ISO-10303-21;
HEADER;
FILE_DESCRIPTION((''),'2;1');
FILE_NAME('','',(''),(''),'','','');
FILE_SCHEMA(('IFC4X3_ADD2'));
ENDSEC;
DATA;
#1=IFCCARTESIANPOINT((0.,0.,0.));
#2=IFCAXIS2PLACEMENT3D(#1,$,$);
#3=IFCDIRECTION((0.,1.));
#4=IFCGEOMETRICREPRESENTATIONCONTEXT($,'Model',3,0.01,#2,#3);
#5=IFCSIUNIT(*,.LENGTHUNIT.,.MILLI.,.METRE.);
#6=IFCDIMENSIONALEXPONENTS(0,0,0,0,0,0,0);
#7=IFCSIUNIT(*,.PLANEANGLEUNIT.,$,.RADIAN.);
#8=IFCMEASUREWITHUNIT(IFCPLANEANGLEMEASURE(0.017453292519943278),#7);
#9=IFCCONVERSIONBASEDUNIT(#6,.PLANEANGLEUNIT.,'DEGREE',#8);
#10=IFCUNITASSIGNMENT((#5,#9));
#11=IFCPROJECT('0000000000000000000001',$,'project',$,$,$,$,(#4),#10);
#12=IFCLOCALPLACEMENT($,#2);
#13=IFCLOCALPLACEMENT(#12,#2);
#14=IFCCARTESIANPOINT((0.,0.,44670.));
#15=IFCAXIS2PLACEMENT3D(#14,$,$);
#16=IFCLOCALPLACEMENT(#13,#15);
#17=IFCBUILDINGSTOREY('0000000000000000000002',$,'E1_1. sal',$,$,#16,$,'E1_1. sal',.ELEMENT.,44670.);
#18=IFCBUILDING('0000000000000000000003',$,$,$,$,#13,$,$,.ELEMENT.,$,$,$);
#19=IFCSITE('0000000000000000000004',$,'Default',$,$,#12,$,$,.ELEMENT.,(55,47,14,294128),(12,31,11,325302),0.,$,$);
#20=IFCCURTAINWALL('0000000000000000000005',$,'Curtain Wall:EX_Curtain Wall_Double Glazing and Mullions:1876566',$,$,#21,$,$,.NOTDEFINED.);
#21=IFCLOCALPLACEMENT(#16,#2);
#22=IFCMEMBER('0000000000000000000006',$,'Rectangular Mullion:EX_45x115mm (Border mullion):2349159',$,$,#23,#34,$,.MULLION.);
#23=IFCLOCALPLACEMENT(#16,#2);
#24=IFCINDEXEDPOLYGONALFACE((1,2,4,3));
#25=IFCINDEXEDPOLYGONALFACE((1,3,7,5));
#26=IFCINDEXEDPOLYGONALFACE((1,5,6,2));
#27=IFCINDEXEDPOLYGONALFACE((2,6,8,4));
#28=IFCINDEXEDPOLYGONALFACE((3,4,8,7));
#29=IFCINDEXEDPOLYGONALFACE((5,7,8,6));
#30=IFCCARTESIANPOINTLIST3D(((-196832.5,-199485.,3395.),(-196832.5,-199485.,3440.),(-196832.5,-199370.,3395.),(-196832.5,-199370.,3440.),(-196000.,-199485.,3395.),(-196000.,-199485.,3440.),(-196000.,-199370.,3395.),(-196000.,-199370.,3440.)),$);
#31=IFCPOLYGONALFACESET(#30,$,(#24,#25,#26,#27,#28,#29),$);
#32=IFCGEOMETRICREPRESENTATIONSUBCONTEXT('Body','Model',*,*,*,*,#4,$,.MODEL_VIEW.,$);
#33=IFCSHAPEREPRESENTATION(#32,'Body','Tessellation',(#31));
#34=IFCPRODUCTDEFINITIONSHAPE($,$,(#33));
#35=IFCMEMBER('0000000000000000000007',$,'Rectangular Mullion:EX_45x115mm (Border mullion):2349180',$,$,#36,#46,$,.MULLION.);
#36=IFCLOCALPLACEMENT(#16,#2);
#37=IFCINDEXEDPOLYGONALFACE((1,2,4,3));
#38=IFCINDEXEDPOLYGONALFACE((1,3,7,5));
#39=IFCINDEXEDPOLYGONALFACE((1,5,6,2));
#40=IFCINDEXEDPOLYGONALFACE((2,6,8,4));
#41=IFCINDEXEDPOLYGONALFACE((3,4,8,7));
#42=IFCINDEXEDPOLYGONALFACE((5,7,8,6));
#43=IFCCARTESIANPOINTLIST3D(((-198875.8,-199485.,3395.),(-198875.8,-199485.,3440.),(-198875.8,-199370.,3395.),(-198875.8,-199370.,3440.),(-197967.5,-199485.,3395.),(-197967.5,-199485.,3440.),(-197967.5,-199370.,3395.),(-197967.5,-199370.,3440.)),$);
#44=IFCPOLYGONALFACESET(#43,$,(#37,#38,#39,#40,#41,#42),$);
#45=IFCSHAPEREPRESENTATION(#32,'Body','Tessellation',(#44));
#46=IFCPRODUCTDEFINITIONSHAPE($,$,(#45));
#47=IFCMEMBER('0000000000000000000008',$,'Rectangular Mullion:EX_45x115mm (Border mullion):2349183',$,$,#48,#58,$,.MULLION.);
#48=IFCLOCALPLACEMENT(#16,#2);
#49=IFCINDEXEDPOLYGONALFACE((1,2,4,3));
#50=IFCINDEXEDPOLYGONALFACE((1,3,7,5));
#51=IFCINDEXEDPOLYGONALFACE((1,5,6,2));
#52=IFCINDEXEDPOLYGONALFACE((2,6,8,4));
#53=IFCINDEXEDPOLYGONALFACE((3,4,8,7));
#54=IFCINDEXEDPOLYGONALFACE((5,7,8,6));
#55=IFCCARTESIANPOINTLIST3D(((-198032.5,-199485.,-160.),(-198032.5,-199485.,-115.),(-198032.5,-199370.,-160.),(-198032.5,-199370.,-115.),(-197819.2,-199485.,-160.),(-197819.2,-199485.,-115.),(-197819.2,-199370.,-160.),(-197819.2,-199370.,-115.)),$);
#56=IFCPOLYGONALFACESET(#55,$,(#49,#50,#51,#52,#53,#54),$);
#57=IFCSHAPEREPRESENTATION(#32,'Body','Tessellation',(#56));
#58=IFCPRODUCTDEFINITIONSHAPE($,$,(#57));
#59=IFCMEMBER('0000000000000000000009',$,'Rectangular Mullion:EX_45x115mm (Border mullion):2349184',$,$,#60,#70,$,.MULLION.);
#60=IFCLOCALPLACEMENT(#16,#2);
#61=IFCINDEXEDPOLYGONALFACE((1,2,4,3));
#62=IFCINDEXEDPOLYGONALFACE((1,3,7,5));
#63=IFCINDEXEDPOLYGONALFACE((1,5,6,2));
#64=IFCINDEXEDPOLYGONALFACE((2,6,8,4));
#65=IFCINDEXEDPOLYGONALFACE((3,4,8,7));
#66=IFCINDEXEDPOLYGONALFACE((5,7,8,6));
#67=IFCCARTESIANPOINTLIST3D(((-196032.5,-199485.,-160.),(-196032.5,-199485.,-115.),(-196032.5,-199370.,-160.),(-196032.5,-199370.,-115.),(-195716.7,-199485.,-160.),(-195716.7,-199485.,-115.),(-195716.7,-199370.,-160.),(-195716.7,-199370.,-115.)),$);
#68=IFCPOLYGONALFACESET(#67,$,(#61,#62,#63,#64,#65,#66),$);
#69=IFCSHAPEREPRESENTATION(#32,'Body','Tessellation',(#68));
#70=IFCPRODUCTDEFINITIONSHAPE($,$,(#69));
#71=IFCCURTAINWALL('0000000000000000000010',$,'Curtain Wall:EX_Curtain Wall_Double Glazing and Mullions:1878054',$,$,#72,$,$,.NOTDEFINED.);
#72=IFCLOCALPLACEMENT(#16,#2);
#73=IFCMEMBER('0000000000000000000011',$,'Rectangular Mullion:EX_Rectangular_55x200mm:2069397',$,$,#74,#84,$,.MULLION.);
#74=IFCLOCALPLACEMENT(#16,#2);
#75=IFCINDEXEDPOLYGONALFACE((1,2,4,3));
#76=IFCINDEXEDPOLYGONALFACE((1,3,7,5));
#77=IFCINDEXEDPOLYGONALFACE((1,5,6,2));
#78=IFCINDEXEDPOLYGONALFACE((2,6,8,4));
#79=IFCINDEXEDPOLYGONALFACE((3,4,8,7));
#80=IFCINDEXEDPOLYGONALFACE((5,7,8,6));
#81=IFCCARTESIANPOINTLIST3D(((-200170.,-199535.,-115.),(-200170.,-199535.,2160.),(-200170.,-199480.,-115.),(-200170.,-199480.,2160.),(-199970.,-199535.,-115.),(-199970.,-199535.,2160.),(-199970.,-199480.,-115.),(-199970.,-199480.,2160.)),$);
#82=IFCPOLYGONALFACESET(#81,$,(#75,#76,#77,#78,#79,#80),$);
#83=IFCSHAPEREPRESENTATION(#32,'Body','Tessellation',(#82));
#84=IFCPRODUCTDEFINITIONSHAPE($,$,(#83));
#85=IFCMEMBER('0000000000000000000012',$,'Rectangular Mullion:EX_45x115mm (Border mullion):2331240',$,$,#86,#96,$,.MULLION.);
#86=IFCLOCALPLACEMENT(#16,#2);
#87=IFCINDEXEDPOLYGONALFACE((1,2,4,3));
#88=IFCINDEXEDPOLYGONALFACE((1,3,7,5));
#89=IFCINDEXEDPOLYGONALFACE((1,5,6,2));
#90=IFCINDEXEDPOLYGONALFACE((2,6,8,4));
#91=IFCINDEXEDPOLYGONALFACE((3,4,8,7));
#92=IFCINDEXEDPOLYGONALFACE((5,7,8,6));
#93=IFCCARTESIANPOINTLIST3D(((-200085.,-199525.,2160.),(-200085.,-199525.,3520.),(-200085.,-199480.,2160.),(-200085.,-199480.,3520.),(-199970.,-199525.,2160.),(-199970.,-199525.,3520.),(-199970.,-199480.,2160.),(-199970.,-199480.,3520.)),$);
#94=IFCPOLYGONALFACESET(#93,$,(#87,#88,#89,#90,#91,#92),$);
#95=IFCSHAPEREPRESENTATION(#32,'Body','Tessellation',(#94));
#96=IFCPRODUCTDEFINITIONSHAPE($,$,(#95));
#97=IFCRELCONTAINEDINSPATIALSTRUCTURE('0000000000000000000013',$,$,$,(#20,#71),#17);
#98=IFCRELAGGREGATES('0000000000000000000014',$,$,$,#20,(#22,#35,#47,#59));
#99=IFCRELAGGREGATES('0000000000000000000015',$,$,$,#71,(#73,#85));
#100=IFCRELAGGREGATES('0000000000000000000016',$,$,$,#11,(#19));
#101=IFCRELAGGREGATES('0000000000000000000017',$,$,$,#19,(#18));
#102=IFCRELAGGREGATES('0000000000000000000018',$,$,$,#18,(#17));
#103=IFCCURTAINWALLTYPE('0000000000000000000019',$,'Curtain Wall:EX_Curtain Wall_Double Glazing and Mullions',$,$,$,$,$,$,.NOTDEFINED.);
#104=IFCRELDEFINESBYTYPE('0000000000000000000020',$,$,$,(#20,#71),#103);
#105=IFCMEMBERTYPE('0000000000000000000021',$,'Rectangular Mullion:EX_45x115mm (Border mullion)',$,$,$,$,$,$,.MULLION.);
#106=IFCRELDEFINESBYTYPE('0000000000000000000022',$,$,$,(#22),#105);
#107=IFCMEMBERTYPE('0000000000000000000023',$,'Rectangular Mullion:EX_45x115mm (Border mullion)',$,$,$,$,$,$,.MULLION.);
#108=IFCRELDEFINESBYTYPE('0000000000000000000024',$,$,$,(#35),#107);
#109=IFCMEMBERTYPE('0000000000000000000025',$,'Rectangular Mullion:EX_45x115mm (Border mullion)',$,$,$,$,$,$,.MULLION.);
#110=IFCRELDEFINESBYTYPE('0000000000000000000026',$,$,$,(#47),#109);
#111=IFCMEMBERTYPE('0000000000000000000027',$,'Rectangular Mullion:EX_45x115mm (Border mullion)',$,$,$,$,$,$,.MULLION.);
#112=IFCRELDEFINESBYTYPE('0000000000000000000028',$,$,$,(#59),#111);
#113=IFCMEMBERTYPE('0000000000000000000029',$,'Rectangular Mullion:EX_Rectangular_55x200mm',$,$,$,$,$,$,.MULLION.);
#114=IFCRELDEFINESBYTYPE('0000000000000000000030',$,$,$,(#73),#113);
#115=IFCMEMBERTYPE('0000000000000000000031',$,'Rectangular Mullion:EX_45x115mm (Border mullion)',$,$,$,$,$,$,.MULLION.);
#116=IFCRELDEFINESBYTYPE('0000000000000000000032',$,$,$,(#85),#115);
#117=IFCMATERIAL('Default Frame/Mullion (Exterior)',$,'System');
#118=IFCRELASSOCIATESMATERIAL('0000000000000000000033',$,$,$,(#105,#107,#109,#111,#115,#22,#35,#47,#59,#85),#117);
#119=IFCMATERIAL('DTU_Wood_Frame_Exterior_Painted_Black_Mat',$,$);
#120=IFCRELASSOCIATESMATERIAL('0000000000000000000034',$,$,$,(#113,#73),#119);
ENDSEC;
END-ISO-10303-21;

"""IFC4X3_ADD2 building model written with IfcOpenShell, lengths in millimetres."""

from ifc_helpers import new_model, entity, si_unit, converted_unit, direction, frame, origin, origin_2d_with_axis, place, context, subcontext, project, spatial, rectangle, extrude, source, transform, mapped, material, material_profile, profile_set, profile_usage, type_object, type_shapes, element, aggregate, save


model = new_model("IFC4X3_ADD2")

# Units and contexts
model_context = context("Model", 3, precision=0.01, world=origin(), true_north=direction((0.0, 1.0)))
body_context = subcontext(model_context, "Body", "Model", "MODEL_VIEW")
ifc_project = project(units=[si_unit("LENGTHUNIT", "METRE", prefix="MILLI"), converted_unit("PLANEANGLEUNIT", "DEGREE", entity("IfcPlaneAngleMeasure", 0.017453292519943278), si_unit("PLANEANGLEUNIT", "RADIAN"), dimensions=[0, 0, 0, 0, 0, 0, 0])], contexts=[model_context])

# Site, building, storey
site_placement = place(None, origin())
site = spatial("IfcSite", under=ifc_project, at=site_placement, Name="Default", CompositionType="ELEMENT", RefLatitude=(55, 47, 14, 294128), RefLongitude=(12, 31, 11, 325302), RefElevation=0.0)
building_placement = place(site_placement, origin())
building = spatial("IfcBuilding", under=site, at=building_placement, CompositionType="ELEMENT")
storey_placement = place(building_placement, frame((0.0, 0.0, 44670.0)))
storey = spatial("IfcBuildingStorey", under=building, at=storey_placement, Name="E1_1. sal", LongName="E1_1. sal", CompositionType="ELEMENT", Elevation=44670.0)

# Curtain walls, members
curtain_wall_type = type_object("IfcCurtainWallType", Name="Curtain Wall:EX_Curtain Wall_Double Glazing and Mullions", PredefinedType="NOTDEFINED")
curtain_wall_1_placement = place(storey_placement, frame((0.0, 0.0, -44670.0)))
curtain_wall_1 = element("IfcCurtainWall", 1, at=curtain_wall_1_placement, inside=storey, type_object=curtain_wall_type, Name="Curtain Wall:EX_Curtain Wall_Double Glazing and Mullions:1876566", PredefinedType="NOTDEFINED")
ifc_material_1 = material(Name="DTU_Wood_Frame_Exterior_Painted_Black_Mat")
ifc_material_profile_1 = material_profile(ifc_material_1, rectangle(XDim=55.0, YDim=200.0, at=origin_2d_with_axis()), Name="EX_Rectangular_55x200mm")
ifc_profile_set_1 = profile_set([ifc_material_profile_1], Name="EX_Rectangular_55x200mm")
ifc_profile_usage_1 = profile_usage(ifc_profile_set_1)
ifc_material_2 = material(Name="Default Frame/Mullion (Exterior)", Category="System")
ifc_material_profile_2 = material_profile(ifc_material_2, rectangle(XDim=45.0, YDim=115.0, at=origin_2d_with_axis()), Name="EX_45x115mm (Border mullion)")
ifc_profile_set_2 = profile_set([ifc_material_profile_2], Name="EX_45x115mm (Border mullion)")
ifc_profile_usage_2 = profile_usage(ifc_profile_set_2)
member_type_1 = type_object("IfcMemberType", Name="Rectangular Mullion:EX_45x115mm (Border mullion)", PredefinedType="MULLION", material=ifc_profile_set_2)
shared_shape_1 = source(origin(), body_context, "Body", "SweptSolid", [
    extrude(rectangle(XDim=45.0, YDim=115.0, at=origin_2d_with_axis()), frame((-22.5, -57.5, -832.5), z_axis=(0.0, 0.0, 1.0), x_axis=(-1.0, 0.0, 0.0)), (0.0, 0.0, 1.0), 832.5),
])
type_shapes(member_type_1, [shared_shape_1])
member_1_placement = place(curtain_wall_1_placement, frame((-196000.0, -199485.0, 48110.0), z_axis=(1.0, 0.0, 0.0), x_axis=(0.0, 0.0, 1.0)))
member_1 = element("IfcMember", 2, at=member_1_placement, type_object=member_type_1, material=ifc_profile_usage_2, Name="Rectangular Mullion:EX_45x115mm (Border mullion):2349159", PredefinedType="MULLION", context=body_context, shape_type="MappedRepresentation", body=[
    mapped(shared_shape_1, transform((0.0, 0.0, 0.0), scale=1.0)),
])
member_type_2 = type_object("IfcMemberType", Name="Rectangular Mullion:EX_45x115mm (Border mullion)", PredefinedType="MULLION", material=ifc_profile_set_2)
shared_shape_2 = source(origin(), body_context, "Body", "SweptSolid", [
    extrude(rectangle(XDim=45.0, YDim=115.0, at=origin_2d_with_axis()), frame((-22.5, -57.5, -908.3), z_axis=(0.0, 0.0, 1.0), x_axis=(-1.0, 0.0, 0.0)), (0.0, 0.0, 1.0), 908.3),
])
type_shapes(member_type_2, [shared_shape_2])
member_2_placement = place(curtain_wall_1_placement, frame((-197967.5, -199485.0, 48110.0), z_axis=(1.0, 0.0, 0.0), x_axis=(0.0, 0.0, 1.0)))
member_2 = element("IfcMember", 3, at=member_2_placement, type_object=member_type_2, material=ifc_profile_usage_2, Name="Rectangular Mullion:EX_45x115mm (Border mullion):2349180", PredefinedType="MULLION", context=body_context, shape_type="MappedRepresentation", body=[
    mapped(shared_shape_2, transform((0.0, 0.0, 0.0), scale=1.0)),
])
member_type_3 = type_object("IfcMemberType", Name="Rectangular Mullion:EX_45x115mm (Border mullion)", PredefinedType="MULLION", material=ifc_profile_set_2)
shared_shape_3 = source(origin(), body_context, "Body", "SweptSolid", [
    extrude(rectangle(XDim=45.0, YDim=115.0, at=origin_2d_with_axis()), frame((-22.5, -57.5, -213.3), z_axis=(0.0, 0.0, 1.0), x_axis=(-1.0, 0.0, 0.0)), (0.0, 0.0, 1.0), 213.3),
])
type_shapes(member_type_3, [shared_shape_3])
member_3_placement = place(curtain_wall_1_placement, frame((-198032.5, -199485.0, 44510.0), z_axis=(-1.0, 0.0, 0.0), x_axis=(0.0, 0.0, -1.0)))
member_3 = element("IfcMember", 4, at=member_3_placement, type_object=member_type_3, material=ifc_profile_usage_2, Name="Rectangular Mullion:EX_45x115mm (Border mullion):2349183", PredefinedType="MULLION", context=body_context, shape_type="MappedRepresentation", body=[
    mapped(shared_shape_3, transform((0.0, 0.0, 0.0), scale=1.0)),
])
member_type_4 = type_object("IfcMemberType", Name="Rectangular Mullion:EX_45x115mm (Border mullion)", PredefinedType="MULLION", material=ifc_profile_set_2)
shared_shape_4 = source(origin(), body_context, "Body", "SweptSolid", [
    extrude(rectangle(XDim=45.0, YDim=115.0, at=origin_2d_with_axis()), frame((-22.5, -57.5, -315.8), z_axis=(0.0, 0.0, 1.0), x_axis=(-1.0, 0.0, 0.0)), (0.0, 0.0, 1.0), 315.8),
])
type_shapes(member_type_4, [shared_shape_4])
member_4_placement = place(curtain_wall_1_placement, frame((-196032.5, -199485.0, 44510.0), z_axis=(-1.0, 0.0, 0.0), x_axis=(0.0, 0.0, -1.0)))
member_4 = element("IfcMember", 5, at=member_4_placement, type_object=member_type_4, material=ifc_profile_usage_2, Name="Rectangular Mullion:EX_45x115mm (Border mullion):2349184", PredefinedType="MULLION", context=body_context, shape_type="MappedRepresentation", body=[
    mapped(shared_shape_4, transform((0.0, 0.0, 0.0), scale=1.0)),
])
aggregate(curtain_wall_1, [member_1, member_2, member_3, member_4])
curtain_wall_2_placement = place(storey_placement, frame((0.0, 0.0, -44670.0)))
curtain_wall_2 = element("IfcCurtainWall", 6, at=curtain_wall_2_placement, inside=storey, type_object=curtain_wall_type, Name="Curtain Wall:EX_Curtain Wall_Double Glazing and Mullions:1878054", PredefinedType="NOTDEFINED")
member_type_5 = type_object("IfcMemberType", Name="Rectangular Mullion:EX_Rectangular_55x200mm", PredefinedType="MULLION", material=ifc_profile_set_1)
shared_shape_5 = source(origin(), body_context, "Body", "SweptSolid", [
    extrude(rectangle(XDim=55.0, YDim=200.0, at=origin_2d_with_axis()), frame((-27.5, -100.0, -2275.0), z_axis=(0.0, 0.0, 1.0), x_axis=(-1.0, 0.0, 0.0)), (0.0, 0.0, 1.0), 2275.0),
])
type_shapes(member_type_5, [shared_shape_5])
member_5_placement = place(curtain_wall_2_placement, frame((-199970.0, -199480.0, 44555.0), z_axis=(0.0, 0.0, -1.0), x_axis=(0.0, 1.0, 0.0)))
member_5 = element("IfcMember", 7, at=member_5_placement, type_object=member_type_5, material=ifc_profile_usage_1, Name="Rectangular Mullion:EX_Rectangular_55x200mm:2069397", PredefinedType="MULLION", context=body_context, shape_type="MappedRepresentation", body=[
    mapped(shared_shape_5, transform((0.0, 0.0, 0.0), scale=1.0)),
])
member_type_6 = type_object("IfcMemberType", Name="Rectangular Mullion:EX_45x115mm (Border mullion)", PredefinedType="MULLION", material=ifc_profile_set_2)
shared_shape_6 = source(origin(), body_context, "Body", "SweptSolid", [
    extrude(rectangle(XDim=45.0, YDim=115.0, at=origin_2d_with_axis()), frame((-22.5, -57.5, -1360.0), z_axis=(0.0, 0.0, 1.0), x_axis=(-1.0, 0.0, 0.0)), (0.0, 0.0, 1.0), 1360.0),
])
type_shapes(member_type_6, [shared_shape_6])
member_6_placement = place(curtain_wall_2_placement, frame((-199970.0, -199480.0, 46830.0), z_axis=(0.0, 0.0, -1.0), x_axis=(0.0, 1.0, 0.0)))
member_6 = element("IfcMember", 8, at=member_6_placement, type_object=member_type_6, material=ifc_profile_usage_2, Name="Rectangular Mullion:EX_45x115mm (Border mullion):2331240", PredefinedType="MULLION", context=body_context, shape_type="MappedRepresentation", body=[
    mapped(shared_shape_6, transform((0.0, 0.0, 0.0), scale=1.0)),
])
aggregate(curtain_wall_2, [member_5, member_6])

save(model, "model.ifc")
